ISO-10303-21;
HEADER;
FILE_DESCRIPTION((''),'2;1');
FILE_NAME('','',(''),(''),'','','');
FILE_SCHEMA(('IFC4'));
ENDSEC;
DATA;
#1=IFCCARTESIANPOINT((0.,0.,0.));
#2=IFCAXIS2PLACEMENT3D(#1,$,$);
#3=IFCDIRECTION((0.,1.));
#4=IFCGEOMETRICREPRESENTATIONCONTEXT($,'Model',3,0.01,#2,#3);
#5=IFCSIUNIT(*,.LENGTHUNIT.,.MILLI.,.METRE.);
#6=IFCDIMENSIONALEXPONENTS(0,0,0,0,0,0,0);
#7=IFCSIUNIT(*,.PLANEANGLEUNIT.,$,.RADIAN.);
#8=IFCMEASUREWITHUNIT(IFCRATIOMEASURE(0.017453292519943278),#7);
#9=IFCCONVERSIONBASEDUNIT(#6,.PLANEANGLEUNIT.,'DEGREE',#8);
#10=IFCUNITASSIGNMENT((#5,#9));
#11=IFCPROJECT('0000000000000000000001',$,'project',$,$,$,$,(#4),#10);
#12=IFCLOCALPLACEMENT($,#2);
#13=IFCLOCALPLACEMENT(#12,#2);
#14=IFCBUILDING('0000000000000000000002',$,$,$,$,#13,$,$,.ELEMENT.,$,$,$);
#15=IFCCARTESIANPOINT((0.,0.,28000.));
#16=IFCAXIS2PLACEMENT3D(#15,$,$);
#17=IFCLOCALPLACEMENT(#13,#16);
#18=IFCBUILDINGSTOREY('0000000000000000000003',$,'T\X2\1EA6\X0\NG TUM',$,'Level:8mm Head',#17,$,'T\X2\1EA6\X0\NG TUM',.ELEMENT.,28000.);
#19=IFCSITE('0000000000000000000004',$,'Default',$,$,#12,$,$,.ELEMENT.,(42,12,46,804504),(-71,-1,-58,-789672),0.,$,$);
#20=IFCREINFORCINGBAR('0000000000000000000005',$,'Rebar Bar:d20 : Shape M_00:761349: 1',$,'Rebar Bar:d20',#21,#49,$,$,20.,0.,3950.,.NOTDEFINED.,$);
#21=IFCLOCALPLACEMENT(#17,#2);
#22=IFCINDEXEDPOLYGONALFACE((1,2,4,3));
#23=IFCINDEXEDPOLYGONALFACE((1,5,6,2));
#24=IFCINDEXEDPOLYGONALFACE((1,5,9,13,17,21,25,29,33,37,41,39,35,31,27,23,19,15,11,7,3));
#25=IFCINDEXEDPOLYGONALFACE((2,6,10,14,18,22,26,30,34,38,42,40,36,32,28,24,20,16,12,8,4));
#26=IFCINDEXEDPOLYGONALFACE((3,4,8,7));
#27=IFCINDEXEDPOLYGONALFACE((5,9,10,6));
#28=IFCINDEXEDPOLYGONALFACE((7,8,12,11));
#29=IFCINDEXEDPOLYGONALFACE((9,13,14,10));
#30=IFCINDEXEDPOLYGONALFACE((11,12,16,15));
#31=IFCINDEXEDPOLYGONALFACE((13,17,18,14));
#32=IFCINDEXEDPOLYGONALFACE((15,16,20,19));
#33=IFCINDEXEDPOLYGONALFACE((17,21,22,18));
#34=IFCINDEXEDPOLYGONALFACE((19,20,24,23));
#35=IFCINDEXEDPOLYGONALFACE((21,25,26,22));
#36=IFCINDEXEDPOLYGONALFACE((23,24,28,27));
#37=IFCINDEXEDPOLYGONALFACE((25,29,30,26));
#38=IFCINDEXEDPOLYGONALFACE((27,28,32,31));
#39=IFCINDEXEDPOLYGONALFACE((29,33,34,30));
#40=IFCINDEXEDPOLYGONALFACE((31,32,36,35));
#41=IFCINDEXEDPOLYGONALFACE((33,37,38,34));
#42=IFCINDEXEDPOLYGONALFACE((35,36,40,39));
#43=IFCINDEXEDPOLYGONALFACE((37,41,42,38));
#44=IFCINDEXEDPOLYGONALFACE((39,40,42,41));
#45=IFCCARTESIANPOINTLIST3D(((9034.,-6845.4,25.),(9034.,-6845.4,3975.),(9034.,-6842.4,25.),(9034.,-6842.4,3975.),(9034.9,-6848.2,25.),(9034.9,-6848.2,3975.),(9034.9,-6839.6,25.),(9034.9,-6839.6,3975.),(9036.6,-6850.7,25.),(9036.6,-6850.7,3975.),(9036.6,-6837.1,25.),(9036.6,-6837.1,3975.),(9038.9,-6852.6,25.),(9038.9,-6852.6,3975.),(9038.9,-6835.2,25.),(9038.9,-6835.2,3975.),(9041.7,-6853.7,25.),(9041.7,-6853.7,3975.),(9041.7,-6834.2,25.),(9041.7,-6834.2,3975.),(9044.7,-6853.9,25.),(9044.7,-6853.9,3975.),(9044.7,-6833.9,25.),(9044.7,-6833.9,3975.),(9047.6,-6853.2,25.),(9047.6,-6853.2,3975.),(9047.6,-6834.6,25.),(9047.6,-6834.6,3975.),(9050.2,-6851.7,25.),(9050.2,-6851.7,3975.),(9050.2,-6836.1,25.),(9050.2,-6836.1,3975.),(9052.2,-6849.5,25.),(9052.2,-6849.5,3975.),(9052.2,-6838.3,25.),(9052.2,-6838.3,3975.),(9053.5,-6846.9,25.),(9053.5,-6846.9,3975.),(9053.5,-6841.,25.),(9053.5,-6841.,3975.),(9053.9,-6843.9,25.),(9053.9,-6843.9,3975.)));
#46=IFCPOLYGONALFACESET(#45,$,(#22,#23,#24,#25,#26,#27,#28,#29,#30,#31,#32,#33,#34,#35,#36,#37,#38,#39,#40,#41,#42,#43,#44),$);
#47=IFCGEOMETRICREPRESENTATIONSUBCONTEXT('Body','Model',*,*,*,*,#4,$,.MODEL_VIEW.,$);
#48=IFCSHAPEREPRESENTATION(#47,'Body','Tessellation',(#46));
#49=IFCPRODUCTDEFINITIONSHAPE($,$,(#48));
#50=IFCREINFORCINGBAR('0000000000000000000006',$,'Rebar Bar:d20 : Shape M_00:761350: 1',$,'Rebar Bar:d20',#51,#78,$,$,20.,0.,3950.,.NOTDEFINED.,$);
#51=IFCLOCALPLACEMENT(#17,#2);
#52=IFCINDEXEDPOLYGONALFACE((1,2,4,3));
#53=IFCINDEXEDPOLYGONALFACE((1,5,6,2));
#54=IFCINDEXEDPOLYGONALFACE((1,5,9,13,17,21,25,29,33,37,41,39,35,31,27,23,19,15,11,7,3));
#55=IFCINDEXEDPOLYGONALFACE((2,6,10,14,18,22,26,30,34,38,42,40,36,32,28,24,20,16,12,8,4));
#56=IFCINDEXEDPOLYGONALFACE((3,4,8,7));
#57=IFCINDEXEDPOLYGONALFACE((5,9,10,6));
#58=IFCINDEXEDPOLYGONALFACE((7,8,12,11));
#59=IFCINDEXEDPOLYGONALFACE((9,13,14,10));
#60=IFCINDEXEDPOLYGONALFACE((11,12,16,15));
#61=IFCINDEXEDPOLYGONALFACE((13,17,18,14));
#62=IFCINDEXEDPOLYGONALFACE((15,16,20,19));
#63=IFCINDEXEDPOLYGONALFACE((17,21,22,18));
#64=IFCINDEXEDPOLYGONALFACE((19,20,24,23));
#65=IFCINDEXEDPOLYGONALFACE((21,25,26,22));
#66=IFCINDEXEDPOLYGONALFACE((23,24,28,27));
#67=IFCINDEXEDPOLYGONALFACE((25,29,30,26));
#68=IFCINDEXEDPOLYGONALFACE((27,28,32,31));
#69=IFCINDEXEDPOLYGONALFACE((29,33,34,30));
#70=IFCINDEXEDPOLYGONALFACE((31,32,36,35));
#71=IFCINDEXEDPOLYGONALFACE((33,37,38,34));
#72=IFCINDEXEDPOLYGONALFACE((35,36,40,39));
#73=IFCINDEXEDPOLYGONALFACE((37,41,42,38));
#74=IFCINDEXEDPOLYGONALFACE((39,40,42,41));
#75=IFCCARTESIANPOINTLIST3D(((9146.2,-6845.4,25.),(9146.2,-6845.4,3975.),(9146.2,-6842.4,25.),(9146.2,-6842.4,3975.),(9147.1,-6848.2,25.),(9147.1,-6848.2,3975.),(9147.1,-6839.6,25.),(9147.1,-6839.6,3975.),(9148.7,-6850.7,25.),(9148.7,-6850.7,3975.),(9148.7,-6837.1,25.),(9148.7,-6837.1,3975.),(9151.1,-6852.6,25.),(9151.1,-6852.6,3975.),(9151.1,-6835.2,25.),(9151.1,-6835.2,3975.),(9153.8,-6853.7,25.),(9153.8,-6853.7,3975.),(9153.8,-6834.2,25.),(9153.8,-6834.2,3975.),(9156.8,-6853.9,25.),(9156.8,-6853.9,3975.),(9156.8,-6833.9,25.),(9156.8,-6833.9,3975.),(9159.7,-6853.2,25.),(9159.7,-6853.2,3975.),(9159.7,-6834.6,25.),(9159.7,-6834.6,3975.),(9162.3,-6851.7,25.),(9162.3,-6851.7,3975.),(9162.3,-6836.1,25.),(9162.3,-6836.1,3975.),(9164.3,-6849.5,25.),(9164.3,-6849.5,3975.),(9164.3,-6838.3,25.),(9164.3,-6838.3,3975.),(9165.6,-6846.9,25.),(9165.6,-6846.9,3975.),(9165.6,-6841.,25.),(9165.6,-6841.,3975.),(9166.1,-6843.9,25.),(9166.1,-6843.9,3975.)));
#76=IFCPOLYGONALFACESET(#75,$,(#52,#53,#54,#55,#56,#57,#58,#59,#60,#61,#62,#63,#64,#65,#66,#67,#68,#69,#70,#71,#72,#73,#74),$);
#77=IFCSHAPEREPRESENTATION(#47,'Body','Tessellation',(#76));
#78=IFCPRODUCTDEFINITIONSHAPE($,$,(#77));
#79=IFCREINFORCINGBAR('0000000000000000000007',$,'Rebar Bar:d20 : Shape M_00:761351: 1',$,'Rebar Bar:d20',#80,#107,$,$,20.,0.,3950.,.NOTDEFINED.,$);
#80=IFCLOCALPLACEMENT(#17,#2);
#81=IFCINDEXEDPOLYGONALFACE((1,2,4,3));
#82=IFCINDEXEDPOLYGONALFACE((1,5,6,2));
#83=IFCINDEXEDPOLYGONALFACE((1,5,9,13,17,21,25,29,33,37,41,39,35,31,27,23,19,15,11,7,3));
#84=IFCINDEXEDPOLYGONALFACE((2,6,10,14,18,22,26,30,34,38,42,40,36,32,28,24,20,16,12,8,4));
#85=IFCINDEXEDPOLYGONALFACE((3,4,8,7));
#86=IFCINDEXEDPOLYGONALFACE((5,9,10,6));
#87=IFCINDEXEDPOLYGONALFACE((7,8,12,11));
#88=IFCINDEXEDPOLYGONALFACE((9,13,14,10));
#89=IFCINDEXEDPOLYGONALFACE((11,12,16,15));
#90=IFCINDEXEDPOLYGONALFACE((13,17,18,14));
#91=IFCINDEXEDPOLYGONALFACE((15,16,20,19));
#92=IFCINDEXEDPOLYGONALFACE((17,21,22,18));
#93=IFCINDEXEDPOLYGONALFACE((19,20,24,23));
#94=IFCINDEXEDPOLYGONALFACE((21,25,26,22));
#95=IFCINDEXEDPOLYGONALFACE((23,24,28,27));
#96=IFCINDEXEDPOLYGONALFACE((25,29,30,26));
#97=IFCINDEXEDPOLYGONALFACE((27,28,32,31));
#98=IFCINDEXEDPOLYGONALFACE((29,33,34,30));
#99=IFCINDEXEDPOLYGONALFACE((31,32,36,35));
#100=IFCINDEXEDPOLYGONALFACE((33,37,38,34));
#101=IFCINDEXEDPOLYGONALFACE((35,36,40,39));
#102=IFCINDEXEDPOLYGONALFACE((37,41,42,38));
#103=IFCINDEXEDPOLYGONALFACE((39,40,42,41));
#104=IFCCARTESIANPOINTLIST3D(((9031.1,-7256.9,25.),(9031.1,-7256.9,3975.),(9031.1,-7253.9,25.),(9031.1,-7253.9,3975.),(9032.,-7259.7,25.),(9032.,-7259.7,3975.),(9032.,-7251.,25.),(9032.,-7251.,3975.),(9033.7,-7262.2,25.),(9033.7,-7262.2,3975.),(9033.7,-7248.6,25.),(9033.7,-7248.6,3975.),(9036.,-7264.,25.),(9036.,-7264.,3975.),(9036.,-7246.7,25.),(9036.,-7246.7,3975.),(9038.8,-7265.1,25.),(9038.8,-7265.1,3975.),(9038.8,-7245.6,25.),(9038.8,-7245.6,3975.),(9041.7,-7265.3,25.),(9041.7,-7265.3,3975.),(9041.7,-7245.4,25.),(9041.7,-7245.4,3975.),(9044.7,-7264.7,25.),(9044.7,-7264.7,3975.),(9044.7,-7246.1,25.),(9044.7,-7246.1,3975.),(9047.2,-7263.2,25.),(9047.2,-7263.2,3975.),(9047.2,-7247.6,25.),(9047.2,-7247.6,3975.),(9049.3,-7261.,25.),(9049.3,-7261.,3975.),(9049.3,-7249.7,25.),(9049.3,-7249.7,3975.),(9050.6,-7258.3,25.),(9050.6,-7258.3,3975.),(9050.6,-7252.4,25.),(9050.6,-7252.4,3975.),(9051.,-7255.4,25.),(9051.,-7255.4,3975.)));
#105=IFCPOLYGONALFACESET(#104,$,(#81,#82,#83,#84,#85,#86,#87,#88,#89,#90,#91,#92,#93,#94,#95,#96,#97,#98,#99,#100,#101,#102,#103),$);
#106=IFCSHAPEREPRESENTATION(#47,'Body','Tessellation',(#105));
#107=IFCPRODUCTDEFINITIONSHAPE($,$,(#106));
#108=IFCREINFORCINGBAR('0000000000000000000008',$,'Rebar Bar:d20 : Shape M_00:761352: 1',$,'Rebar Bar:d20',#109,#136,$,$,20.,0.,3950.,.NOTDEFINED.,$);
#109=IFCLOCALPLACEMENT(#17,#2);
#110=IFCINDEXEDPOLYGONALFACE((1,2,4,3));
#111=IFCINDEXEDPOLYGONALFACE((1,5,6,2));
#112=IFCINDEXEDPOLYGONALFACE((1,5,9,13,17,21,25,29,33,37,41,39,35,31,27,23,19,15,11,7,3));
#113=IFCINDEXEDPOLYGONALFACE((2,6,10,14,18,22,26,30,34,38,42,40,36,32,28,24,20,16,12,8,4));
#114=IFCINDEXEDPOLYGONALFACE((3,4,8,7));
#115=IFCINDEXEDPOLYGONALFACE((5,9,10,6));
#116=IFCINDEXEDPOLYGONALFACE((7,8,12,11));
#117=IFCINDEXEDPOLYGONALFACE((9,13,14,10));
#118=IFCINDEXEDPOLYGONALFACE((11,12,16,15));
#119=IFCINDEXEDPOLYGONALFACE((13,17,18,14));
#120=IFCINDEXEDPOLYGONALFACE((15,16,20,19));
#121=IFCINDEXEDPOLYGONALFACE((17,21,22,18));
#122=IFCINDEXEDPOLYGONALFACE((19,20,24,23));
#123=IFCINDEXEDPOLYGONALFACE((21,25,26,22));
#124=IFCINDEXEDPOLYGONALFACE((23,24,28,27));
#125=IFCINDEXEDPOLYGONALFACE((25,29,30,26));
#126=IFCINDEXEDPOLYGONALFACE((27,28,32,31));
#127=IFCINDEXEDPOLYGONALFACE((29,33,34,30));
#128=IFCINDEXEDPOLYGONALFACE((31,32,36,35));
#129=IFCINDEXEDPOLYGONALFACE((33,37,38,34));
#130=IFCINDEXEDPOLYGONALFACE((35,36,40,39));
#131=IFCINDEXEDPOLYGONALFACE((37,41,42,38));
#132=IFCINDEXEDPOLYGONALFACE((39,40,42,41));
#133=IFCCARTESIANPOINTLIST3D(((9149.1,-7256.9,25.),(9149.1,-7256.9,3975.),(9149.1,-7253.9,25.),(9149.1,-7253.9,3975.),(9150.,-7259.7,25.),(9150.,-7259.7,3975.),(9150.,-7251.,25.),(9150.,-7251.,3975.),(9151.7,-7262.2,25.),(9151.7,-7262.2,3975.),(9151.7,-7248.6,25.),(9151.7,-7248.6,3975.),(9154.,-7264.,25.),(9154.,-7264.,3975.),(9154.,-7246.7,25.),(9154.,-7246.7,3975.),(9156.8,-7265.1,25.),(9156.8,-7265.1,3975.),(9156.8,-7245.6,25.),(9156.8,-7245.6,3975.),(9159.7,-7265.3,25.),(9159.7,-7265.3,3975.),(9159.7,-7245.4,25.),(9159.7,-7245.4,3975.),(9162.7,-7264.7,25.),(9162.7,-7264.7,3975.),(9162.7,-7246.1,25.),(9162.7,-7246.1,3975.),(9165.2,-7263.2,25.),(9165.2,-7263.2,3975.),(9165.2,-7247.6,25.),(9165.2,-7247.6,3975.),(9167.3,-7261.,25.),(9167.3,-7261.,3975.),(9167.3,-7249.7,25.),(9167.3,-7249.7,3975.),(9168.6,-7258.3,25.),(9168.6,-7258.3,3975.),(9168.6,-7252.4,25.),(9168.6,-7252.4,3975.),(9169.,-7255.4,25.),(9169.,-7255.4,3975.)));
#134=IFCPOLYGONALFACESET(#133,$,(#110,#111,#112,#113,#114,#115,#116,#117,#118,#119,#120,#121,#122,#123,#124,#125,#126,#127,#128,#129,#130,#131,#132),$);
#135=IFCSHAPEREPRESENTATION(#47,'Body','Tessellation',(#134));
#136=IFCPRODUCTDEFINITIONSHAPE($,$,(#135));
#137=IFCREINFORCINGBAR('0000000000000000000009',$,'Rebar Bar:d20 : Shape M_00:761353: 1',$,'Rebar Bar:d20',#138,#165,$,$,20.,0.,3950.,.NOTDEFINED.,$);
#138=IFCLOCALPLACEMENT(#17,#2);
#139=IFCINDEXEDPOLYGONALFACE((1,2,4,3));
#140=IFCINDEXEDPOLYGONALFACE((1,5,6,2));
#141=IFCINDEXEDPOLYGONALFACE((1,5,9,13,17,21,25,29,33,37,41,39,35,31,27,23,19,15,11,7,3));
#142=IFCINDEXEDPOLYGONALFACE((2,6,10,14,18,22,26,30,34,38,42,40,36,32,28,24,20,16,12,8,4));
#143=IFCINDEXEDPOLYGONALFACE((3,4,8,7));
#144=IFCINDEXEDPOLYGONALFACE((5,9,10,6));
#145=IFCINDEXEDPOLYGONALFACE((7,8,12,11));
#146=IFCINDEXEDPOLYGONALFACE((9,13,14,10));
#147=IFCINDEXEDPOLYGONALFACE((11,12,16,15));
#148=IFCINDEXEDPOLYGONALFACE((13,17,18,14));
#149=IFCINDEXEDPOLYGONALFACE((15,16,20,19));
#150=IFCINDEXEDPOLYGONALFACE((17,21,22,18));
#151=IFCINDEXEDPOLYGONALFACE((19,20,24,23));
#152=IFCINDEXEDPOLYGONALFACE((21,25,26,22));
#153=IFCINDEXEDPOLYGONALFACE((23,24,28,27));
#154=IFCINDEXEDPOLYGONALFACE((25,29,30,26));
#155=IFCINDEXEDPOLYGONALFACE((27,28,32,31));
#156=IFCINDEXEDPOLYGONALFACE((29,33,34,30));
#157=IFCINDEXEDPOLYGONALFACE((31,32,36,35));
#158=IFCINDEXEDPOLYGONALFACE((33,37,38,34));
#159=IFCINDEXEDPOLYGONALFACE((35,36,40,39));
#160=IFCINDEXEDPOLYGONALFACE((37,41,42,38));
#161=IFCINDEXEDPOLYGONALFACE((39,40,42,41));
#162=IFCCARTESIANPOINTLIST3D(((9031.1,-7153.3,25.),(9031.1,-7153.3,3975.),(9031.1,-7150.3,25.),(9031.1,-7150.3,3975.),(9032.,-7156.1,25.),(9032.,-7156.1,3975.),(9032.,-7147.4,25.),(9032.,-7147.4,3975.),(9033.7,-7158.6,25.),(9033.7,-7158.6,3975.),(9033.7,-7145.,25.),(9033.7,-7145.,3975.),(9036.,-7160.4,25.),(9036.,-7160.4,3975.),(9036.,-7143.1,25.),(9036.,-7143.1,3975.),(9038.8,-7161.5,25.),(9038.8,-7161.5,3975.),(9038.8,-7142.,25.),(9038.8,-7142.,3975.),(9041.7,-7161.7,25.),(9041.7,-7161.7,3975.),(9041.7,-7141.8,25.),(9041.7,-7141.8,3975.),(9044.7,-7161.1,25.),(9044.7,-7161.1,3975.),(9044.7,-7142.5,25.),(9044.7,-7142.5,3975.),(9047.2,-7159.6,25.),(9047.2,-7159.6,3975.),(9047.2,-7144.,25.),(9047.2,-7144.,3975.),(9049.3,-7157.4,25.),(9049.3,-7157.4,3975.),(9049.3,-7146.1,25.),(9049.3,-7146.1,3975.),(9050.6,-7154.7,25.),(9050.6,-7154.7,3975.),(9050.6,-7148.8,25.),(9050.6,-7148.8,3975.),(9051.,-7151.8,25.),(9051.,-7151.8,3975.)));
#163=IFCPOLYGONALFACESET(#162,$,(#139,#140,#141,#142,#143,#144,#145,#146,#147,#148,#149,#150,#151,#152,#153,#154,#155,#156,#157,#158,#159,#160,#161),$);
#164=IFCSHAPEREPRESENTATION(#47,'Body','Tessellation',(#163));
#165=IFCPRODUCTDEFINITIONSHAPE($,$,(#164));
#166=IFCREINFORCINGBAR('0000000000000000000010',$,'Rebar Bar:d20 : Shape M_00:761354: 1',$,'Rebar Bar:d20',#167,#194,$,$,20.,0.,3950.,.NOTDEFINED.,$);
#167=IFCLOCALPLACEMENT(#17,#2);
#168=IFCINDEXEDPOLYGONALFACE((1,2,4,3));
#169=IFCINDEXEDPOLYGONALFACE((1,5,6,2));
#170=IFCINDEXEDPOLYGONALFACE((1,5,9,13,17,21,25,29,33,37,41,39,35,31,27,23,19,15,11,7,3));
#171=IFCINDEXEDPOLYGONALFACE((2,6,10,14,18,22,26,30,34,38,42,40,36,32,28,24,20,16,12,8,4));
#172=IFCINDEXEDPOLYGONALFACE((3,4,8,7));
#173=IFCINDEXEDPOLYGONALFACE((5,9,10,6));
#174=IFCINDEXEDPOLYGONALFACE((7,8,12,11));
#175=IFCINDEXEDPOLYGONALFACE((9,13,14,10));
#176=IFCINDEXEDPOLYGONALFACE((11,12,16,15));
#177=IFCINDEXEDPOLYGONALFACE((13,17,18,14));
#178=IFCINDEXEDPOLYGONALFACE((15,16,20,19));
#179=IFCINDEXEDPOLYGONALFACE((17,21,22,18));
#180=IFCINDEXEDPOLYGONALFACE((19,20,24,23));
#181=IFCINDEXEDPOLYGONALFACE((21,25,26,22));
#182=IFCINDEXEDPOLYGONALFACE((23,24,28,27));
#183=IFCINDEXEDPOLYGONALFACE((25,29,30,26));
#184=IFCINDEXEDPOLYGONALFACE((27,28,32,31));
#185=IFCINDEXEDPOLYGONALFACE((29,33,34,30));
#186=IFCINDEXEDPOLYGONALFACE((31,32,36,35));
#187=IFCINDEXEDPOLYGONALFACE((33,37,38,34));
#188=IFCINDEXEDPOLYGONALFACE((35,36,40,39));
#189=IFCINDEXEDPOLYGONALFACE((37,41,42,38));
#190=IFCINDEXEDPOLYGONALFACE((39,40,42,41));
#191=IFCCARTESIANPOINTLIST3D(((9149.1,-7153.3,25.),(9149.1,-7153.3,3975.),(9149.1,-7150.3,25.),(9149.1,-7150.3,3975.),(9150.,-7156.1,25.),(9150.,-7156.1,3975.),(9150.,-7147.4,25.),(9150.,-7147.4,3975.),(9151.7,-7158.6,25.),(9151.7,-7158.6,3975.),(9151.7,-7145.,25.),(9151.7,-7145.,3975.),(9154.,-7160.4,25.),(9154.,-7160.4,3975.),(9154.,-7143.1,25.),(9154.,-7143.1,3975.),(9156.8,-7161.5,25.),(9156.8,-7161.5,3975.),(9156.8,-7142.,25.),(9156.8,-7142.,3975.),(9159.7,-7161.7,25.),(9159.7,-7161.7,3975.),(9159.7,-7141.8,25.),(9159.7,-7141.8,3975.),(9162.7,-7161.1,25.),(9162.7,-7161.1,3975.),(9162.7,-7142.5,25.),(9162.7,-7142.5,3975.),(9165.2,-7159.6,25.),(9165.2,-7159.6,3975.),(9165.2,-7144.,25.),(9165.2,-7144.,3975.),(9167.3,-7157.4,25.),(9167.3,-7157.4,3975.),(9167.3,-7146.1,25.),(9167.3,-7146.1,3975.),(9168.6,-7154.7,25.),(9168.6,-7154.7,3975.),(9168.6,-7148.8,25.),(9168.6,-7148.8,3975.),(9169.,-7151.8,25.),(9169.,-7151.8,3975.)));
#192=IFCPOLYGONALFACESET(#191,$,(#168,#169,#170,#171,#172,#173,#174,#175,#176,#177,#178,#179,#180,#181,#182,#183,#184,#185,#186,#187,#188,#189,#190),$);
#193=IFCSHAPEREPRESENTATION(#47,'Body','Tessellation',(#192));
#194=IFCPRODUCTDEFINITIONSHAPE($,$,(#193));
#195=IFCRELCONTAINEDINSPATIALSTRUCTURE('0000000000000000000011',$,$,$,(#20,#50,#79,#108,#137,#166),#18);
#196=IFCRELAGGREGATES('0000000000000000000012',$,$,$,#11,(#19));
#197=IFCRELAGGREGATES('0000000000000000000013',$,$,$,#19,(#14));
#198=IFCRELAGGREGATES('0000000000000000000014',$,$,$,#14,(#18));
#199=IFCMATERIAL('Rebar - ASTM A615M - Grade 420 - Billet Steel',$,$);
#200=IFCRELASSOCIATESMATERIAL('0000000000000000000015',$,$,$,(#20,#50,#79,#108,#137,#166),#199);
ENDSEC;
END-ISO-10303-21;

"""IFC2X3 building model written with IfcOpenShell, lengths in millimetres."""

from ifc_helpers import new_model, entity, si_unit, converted_unit, direction, frame, origin, place, context, subcontext, project, spatial, material, element, save


model = new_model("IFC2X3")

# Units and contexts
model_context = context("Model", 3, precision=0.01, world=origin(), true_north=direction((0.0, 1.0)))
body_context = subcontext(model_context, "Body", "Model", "MODEL_VIEW")
ifc_project = project(units=[si_unit("LENGTHUNIT", "METRE", prefix="MILLI"), converted_unit("PLANEANGLEUNIT", "DEGREE", entity("IfcRatioMeasure", 0.017453292519943278), si_unit("PLANEANGLEUNIT", "RADIAN"), dimensions=[0, 0, 0, 0, 0, 0, 0])], contexts=[model_context])

# Site, building, storey
site_placement = place(None, origin())
site = spatial("IfcSite", under=ifc_project, at=site_placement, Name="Default", CompositionType="ELEMENT", RefLatitude=(42, 12, 46, 804504), RefLongitude=(-71, -1, -58, -789672), RefElevation=0.0)
building_placement = place(site_placement, origin())
building = spatial("IfcBuilding", under=site, at=building_placement, CompositionType="ELEMENT")
storey_placement = place(building_placement, frame((0.0, 0.0, 28000.0)))
storey = spatial("IfcBuildingStorey", under=building, at=storey_placement, Name="TẦNG TUM", ObjectType="Level:8mm Head", LongName="TẦNG TUM", CompositionType="ELEMENT", Elevation=28000.0)

# Reinforcing bars
ifc_material = material(Name="Rebar - ASTM A615M - Grade 420 - Billet Steel")
reinforcing_bar_1_placement = place(storey_placement, origin())
element("IfcReinforcingBar", 1, at=reinforcing_bar_1_placement, inside=storey, material=ifc_material, Name="Rebar Bar:d20 : Shape M_00:761349: 1", ObjectType="Rebar Bar:d20", BarLength=3950.0, BarRole="NOTDEFINED", CrossSectionArea=0.0, NominalDiameter=20.0, context=body_context, shape_type="AdvancedSweptSolid", body=[
    entity("IfcSweptDiskSolid", entity("IfcCompositeCurve", [entity("IfcCompositeCurveSegment", "CONTINUOUS", True, entity("IfcPolyline", [entity("IfcCartesianPoint", [9043.9, -6843.9, 25.0]), entity("IfcCartesianPoint", [9043.9, -6843.9, 3975.0])]))], False), 10.0, None, 0.0, 1.0),
])
reinforcing_bar_2_placement = place(storey_placement, origin())
element("IfcReinforcingBar", 2, at=reinforcing_bar_2_placement, inside=storey, material=ifc_material, Name="Rebar Bar:d20 : Shape M_00:761350: 1", ObjectType="Rebar Bar:d20", BarLength=3950.0, BarRole="NOTDEFINED", CrossSectionArea=0.0, NominalDiameter=20.0, context=body_context, shape_type="AdvancedSweptSolid", body=[
    entity("IfcSweptDiskSolid", entity("IfcCompositeCurve", [entity("IfcCompositeCurveSegment", "CONTINUOUS", True, entity("IfcPolyline", [entity("IfcCartesianPoint", [9156.1, -6843.9, 25.0]), entity("IfcCartesianPoint", [9156.1, -6843.9, 3975.0])]))], False), 10.0, None, 0.0, 1.0),
])
reinforcing_bar_3_placement = place(storey_placement, origin())
element("IfcReinforcingBar", 3, at=reinforcing_bar_3_placement, inside=storey, material=ifc_material, Name="Rebar Bar:d20 : Shape M_00:761351: 1", ObjectType="Rebar Bar:d20", BarLength=3950.0, BarRole="NOTDEFINED", CrossSectionArea=0.0, NominalDiameter=20.0, context=body_context, shape_type="AdvancedSweptSolid", body=[
    entity("IfcSweptDiskSolid", entity("IfcCompositeCurve", [entity("IfcCompositeCurveSegment", "CONTINUOUS", True, entity("IfcPolyline", [entity("IfcCartesianPoint", [9041.0, -7255.4, 25.0]), entity("IfcCartesianPoint", [9041.0, -7255.4, 3975.0])]))], False), 10.0, None, 0.0, 1.0),
])
reinforcing_bar_4_placement = place(storey_placement, origin())
element("IfcReinforcingBar", 4, at=reinforcing_bar_4_placement, inside=storey, material=ifc_material, Name="Rebar Bar:d20 : Shape M_00:761352: 1", ObjectType="Rebar Bar:d20", BarLength=3950.0, BarRole="NOTDEFINED", CrossSectionArea=0.0, NominalDiameter=20.0, context=body_context, shape_type="AdvancedSweptSolid", body=[
    entity("IfcSweptDiskSolid", entity("IfcCompositeCurve", [entity("IfcCompositeCurveSegment", "CONTINUOUS", True, entity("IfcPolyline", [entity("IfcCartesianPoint", [9159.0, -7255.4, 25.0]), entity("IfcCartesianPoint", [9159.0, -7255.4, 3975.0])]))], False), 10.0, None, 0.0, 1.0),
])
reinforcing_bar_5_placement = place(storey_placement, origin())
element("IfcReinforcingBar", 5, at=reinforcing_bar_5_placement, inside=storey, material=ifc_material, Name="Rebar Bar:d20 : Shape M_00:761353: 1", ObjectType="Rebar Bar:d20", BarLength=3950.0, BarRole="NOTDEFINED", CrossSectionArea=0.0, NominalDiameter=20.0, context=body_context, shape_type="AdvancedSweptSolid", body=[
    entity("IfcSweptDiskSolid", entity("IfcCompositeCurve", [entity("IfcCompositeCurveSegment", "CONTINUOUS", True, entity("IfcPolyline", [entity("IfcCartesianPoint", [9041.0, -7151.8, 25.0]), entity("IfcCartesianPoint", [9041.0, -7151.8, 3975.0])]))], False), 10.0, None, 0.0, 1.0),
])
reinforcing_bar_6_placement = place(storey_placement, origin())
element("IfcReinforcingBar", 6, at=reinforcing_bar_6_placement, inside=storey, material=ifc_material, Name="Rebar Bar:d20 : Shape M_00:761354: 1", ObjectType="Rebar Bar:d20", BarLength=3950.0, BarRole="NOTDEFINED", CrossSectionArea=0.0, NominalDiameter=20.0, context=body_context, shape_type="AdvancedSweptSolid", body=[
    entity("IfcSweptDiskSolid", entity("IfcCompositeCurve", [entity("IfcCompositeCurveSegment", "CONTINUOUS", True, entity("IfcPolyline", [entity("IfcCartesianPoint", [9159.0, -7151.8, 25.0]), entity("IfcCartesianPoint", [9159.0, -7151.8, 3975.0])]))], False), 10.0, None, 0.0, 1.0),
])

save(model, "model.ifc")
